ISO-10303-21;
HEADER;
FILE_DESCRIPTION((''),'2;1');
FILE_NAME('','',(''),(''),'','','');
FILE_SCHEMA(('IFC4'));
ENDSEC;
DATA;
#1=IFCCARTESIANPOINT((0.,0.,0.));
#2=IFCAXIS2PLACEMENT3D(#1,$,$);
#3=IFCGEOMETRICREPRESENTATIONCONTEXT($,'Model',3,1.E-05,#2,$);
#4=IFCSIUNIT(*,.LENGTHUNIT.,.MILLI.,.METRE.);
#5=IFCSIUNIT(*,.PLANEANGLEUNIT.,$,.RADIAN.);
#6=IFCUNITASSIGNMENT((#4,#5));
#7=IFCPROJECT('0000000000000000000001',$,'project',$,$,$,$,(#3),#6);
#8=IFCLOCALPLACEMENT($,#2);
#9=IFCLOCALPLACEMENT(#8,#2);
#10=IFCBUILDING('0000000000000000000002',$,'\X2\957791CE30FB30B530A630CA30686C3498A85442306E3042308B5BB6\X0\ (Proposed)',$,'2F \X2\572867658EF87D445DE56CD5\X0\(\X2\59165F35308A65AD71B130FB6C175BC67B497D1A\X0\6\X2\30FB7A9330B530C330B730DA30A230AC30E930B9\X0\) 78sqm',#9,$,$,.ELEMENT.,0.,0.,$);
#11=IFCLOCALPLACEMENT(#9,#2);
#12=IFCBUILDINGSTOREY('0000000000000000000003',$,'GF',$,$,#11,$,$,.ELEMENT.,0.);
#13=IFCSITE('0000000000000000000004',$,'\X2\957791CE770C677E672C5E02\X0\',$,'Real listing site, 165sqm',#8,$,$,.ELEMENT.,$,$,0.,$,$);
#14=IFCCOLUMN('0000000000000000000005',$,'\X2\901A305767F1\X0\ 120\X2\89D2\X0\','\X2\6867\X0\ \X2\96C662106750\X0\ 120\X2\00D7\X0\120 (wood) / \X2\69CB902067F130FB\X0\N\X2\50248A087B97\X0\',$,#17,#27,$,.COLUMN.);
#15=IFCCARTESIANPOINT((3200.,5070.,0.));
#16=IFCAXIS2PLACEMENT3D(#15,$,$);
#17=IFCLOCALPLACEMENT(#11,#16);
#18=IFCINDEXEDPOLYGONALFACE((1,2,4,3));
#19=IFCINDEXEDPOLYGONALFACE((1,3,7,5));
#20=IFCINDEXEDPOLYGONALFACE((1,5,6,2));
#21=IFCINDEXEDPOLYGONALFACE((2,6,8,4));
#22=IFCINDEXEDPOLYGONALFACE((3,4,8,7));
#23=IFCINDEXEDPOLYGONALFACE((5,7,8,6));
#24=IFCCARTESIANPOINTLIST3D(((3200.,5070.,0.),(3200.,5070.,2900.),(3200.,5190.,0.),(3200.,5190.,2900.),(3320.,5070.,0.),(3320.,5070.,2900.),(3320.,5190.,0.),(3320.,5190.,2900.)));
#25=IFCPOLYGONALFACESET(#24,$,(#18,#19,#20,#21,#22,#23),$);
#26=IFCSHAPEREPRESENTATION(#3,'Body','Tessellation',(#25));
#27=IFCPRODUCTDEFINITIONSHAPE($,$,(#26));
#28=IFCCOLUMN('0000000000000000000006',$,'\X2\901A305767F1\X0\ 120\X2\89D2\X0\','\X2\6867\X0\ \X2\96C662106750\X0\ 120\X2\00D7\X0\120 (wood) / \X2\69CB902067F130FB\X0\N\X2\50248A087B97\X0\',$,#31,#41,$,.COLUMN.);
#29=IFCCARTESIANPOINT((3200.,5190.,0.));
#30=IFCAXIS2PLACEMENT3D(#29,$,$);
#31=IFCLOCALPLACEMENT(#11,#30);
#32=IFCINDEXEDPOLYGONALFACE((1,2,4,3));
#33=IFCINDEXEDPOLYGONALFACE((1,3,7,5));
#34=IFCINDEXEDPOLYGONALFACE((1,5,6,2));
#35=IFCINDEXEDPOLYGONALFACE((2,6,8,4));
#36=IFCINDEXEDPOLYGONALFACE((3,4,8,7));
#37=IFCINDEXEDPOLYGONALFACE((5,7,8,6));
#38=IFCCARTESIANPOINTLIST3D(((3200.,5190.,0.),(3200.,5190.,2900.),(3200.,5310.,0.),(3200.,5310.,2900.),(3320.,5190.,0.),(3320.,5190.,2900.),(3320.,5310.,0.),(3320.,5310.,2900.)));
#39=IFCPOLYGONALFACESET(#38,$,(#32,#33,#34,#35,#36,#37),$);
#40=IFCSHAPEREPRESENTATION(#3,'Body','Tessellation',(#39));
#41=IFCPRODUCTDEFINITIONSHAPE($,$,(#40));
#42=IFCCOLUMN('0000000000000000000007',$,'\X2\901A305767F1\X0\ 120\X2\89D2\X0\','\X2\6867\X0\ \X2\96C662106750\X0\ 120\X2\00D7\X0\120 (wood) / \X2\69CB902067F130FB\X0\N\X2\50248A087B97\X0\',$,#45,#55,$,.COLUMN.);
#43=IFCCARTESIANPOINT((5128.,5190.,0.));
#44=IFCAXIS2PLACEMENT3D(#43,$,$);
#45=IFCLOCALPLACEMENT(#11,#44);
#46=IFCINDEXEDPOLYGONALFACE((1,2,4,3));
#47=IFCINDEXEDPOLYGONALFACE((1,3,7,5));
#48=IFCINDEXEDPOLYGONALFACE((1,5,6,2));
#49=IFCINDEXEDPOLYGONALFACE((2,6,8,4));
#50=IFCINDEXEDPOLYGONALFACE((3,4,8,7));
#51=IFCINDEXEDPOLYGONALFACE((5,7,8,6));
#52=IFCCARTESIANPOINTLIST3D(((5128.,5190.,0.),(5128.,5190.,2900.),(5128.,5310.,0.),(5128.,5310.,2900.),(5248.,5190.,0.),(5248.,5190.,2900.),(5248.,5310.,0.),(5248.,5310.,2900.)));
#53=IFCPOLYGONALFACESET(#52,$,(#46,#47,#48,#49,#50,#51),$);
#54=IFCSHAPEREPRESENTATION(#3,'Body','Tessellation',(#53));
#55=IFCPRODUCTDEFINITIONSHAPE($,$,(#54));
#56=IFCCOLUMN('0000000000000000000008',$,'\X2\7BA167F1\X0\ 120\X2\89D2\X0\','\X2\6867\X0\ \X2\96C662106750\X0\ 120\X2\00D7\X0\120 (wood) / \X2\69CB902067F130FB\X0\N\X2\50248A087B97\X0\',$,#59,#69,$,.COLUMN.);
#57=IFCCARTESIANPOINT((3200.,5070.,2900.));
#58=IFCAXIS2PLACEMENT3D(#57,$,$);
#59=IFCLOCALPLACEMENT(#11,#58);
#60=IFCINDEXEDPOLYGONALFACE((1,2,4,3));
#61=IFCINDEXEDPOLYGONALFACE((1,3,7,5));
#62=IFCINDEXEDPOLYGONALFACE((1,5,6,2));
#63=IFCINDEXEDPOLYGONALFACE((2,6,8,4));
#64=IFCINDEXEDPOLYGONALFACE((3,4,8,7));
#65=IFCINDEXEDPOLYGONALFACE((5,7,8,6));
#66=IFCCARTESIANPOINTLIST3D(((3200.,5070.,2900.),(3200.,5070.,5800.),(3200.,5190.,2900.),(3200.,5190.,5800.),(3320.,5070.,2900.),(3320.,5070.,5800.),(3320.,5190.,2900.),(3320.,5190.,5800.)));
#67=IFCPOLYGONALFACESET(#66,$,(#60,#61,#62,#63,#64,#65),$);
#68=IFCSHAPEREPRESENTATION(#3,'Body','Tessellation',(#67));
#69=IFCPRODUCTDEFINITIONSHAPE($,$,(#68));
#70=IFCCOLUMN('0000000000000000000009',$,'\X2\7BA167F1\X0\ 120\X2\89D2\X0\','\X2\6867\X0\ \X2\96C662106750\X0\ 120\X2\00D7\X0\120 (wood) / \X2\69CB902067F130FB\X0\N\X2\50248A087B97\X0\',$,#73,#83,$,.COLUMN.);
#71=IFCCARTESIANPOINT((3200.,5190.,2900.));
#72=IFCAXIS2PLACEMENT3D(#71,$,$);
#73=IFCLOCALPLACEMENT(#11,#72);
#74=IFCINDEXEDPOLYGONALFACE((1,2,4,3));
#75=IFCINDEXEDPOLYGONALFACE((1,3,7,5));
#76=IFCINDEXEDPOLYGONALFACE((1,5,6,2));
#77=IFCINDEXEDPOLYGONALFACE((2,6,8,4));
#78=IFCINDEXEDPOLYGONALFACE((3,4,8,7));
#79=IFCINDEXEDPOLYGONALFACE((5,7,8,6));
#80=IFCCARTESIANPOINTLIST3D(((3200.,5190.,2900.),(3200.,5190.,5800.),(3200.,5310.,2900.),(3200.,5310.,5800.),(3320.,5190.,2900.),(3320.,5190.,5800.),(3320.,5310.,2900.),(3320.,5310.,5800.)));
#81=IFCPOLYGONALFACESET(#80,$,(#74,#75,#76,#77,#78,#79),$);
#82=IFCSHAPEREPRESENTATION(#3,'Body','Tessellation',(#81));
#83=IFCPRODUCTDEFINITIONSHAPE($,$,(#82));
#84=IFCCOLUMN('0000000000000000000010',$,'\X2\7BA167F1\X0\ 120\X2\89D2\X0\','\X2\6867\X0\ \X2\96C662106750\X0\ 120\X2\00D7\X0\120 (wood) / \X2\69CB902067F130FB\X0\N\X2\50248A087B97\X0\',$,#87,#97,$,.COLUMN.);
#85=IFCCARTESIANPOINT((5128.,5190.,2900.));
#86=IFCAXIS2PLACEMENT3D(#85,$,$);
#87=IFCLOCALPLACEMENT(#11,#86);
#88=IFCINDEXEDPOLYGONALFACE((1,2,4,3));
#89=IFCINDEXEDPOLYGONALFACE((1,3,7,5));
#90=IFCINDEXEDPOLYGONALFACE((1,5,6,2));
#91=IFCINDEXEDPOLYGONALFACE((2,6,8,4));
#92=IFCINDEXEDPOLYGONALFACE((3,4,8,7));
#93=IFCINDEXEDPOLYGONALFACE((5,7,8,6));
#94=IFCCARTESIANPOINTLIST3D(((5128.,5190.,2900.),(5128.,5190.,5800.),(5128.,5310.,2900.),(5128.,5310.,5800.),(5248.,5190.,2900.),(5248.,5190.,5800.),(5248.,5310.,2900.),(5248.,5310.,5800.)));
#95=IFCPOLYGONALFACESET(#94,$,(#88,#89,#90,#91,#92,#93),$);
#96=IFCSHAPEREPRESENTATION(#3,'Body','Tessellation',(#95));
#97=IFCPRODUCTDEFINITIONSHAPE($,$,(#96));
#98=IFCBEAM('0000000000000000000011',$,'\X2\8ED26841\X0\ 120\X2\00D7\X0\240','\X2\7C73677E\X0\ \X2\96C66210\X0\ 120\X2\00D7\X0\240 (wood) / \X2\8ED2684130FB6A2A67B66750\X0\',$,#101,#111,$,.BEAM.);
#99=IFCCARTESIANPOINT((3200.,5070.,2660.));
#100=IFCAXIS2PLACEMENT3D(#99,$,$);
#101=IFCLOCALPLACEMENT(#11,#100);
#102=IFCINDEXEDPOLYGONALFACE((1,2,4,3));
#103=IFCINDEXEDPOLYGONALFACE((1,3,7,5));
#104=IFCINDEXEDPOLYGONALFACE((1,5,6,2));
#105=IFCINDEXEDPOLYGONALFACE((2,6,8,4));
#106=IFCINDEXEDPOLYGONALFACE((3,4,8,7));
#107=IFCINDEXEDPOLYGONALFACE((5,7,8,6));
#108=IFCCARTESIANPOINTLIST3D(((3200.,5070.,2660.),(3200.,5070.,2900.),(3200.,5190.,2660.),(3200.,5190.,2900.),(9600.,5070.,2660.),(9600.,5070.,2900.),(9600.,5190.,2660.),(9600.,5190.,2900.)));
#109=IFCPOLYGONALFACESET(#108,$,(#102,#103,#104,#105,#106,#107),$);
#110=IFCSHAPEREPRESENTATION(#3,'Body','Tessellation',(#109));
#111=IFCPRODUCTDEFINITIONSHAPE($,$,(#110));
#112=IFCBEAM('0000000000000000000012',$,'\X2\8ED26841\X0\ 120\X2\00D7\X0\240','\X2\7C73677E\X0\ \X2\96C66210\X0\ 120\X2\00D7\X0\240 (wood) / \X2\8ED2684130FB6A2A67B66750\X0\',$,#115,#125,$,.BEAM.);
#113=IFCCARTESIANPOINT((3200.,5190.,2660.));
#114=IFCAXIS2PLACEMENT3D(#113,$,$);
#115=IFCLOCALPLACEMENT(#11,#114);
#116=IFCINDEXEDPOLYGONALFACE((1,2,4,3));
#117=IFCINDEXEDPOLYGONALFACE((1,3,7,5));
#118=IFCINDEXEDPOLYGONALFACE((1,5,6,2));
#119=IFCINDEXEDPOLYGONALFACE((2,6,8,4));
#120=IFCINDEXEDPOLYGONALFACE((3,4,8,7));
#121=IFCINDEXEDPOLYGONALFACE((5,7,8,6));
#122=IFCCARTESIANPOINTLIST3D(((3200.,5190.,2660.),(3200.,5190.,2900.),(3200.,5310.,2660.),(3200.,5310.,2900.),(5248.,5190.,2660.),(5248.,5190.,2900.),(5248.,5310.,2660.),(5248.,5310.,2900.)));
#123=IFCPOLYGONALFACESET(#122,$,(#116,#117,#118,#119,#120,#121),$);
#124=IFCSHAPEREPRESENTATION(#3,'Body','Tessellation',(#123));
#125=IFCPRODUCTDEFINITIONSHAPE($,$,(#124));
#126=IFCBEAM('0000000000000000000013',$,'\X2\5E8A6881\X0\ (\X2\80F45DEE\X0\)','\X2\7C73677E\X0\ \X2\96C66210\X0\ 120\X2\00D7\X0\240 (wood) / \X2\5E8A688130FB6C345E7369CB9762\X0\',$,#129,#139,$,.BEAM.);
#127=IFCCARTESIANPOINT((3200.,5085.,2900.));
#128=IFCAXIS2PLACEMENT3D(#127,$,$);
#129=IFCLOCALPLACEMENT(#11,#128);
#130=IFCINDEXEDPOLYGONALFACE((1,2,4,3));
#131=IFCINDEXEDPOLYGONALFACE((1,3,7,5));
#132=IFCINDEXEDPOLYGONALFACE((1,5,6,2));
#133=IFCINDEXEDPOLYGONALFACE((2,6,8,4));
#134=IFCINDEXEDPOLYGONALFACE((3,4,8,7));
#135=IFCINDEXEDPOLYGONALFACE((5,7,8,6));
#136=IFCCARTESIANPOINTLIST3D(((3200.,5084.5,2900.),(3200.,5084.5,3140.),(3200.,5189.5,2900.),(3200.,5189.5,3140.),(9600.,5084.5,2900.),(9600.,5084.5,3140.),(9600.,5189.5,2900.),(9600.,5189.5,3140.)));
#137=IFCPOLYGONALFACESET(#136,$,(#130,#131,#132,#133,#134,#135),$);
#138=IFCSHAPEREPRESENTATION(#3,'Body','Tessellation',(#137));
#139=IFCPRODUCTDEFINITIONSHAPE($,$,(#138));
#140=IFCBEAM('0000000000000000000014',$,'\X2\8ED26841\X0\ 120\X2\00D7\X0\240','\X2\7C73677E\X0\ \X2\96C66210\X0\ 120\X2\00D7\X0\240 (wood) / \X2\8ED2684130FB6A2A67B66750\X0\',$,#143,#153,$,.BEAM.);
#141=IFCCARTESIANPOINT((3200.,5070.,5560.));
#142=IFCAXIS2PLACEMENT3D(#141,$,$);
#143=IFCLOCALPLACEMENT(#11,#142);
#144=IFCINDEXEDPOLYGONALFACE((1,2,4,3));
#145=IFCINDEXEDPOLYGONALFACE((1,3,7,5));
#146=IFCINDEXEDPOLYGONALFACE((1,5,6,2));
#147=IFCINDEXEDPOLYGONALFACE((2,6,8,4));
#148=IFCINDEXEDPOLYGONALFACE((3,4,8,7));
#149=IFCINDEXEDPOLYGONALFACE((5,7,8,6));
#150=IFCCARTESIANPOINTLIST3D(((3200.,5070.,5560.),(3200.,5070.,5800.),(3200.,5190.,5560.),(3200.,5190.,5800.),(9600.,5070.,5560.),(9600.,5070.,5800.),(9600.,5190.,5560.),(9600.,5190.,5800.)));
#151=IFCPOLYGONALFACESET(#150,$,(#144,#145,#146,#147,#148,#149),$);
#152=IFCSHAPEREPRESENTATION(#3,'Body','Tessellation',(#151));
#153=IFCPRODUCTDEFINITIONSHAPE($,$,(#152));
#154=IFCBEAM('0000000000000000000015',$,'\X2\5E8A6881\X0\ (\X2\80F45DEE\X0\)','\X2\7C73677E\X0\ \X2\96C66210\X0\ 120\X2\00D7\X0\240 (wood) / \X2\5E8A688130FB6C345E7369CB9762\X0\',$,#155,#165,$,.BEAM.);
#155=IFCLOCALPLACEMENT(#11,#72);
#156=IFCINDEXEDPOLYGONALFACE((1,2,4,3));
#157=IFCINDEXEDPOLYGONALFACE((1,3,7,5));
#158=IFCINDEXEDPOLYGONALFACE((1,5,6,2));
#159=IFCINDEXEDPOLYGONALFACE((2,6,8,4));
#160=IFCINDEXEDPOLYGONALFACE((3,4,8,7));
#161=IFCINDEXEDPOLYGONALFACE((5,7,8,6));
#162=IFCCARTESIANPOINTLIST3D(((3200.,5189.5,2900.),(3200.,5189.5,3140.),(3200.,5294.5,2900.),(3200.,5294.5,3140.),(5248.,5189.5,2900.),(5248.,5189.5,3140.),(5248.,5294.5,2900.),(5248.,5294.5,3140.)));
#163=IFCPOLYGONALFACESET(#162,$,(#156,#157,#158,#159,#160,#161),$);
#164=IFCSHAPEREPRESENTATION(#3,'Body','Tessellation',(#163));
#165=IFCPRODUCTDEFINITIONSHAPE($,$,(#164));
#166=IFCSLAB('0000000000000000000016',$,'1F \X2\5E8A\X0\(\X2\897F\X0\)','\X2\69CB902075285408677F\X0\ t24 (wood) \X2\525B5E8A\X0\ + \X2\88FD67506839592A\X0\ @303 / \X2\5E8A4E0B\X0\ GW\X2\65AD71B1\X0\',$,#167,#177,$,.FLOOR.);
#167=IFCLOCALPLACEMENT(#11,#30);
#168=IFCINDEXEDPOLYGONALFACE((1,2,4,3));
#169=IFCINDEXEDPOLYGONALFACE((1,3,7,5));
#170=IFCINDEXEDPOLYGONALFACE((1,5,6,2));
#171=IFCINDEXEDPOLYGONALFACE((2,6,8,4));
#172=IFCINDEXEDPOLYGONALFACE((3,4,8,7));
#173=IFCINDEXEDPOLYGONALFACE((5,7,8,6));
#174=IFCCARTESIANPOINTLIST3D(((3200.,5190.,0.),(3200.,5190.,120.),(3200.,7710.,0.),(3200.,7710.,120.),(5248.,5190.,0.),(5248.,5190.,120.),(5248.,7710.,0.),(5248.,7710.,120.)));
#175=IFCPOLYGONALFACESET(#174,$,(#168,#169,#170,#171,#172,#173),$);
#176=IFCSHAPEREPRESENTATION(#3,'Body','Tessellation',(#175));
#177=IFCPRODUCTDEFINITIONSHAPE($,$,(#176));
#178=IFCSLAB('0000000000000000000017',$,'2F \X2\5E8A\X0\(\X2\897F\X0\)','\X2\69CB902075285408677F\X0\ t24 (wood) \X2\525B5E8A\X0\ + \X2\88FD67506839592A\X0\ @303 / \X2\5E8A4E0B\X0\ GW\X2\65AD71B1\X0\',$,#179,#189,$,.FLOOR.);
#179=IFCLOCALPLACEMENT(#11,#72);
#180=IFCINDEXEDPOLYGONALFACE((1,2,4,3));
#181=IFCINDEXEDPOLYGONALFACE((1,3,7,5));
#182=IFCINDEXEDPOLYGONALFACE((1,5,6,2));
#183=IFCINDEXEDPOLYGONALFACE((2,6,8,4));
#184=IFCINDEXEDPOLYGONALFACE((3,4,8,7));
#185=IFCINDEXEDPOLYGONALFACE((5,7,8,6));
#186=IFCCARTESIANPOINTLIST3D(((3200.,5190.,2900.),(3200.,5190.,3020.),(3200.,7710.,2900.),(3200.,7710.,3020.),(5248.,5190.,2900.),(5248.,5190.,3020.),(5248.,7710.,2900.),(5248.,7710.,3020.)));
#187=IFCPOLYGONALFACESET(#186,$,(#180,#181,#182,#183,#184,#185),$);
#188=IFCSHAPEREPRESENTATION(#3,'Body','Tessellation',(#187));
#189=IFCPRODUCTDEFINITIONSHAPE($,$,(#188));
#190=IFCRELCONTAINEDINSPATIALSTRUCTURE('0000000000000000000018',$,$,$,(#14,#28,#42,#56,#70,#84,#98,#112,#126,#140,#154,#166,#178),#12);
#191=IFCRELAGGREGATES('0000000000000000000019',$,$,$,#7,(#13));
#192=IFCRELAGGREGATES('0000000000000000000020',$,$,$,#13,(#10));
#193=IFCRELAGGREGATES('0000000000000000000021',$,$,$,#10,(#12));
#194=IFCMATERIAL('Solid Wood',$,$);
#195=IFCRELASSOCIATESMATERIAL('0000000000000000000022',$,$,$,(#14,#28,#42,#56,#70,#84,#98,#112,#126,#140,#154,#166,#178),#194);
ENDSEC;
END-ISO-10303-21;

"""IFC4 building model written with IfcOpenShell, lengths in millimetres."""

from ifc_helpers import new_model, si_unit, frame, frame_2d, origin, place, context, project, spatial, rectangle, extrude, material, element, save


model = new_model("IFC4")

# Units and contexts
model_context = context("Model", 3, precision=1e-05, world=origin())
ifc_project = project(units=[si_unit("LENGTHUNIT", "METRE", prefix="MILLI"), si_unit("PLANEANGLEUNIT", "RADIAN")], contexts=[model_context])

# Site, building, storey
site_placement = place(None, origin())
site = spatial("IfcSite", under=ifc_project, at=site_placement, Name="長野県松本市", ObjectType="Real listing site, 165sqm", CompositionType="ELEMENT", RefElevation=0.0)
building_placement = place(site_placement, origin())
building = spatial("IfcBuilding", under=site, at=building_placement, Name="長野・サウナと水風呂のある家 (Proposed)", ObjectType="2F 在来軸組工法(外張り断熱・気密等級6・窓サッシペアガラス) 78sqm", CompositionType="ELEMENT", ElevationOfRefHeight=0.0, ElevationOfTerrain=0.0)
storey_placement = place(building_placement, origin())
storey = spatial("IfcBuildingStorey", under=building, at=storey_placement, Name="GF", CompositionType="ELEMENT", Elevation=0.0)

# Columns
ifc_material_1 = material(Name="Solid Wood")
column_1_placement = place(storey_placement, frame((3200.0, 5070.0, 0.0)))
element("IfcColumn", 1, at=column_1_placement, inside=storey, material=ifc_material_1, Name="通し柱 120角", Description="桧 集成材 120×120 (wood) / 構造柱・N値計算", PredefinedType="COLUMN", context=model_context, shape_type="SweptSolid", body=[
    extrude(rectangle(XDim=120.0, YDim=120.0, at=frame_2d((60.0, 60.0))), frame((3200.0, 5070.0, 0.0)), (0.0, 0.0, 1.0), 2900.0),
])
column_2_placement = place(storey_placement, frame((3200.0, 5190.0, 0.0)))
element("IfcColumn", 2, at=column_2_placement, inside=storey, material=ifc_material_1, Name="通し柱 120角", Description="桧 集成材 120×120 (wood) / 構造柱・N値計算", PredefinedType="COLUMN", context=model_context, shape_type="SweptSolid", body=[
    extrude(rectangle(XDim=120.0, YDim=120.0, at=frame_2d((60.0, 60.0))), frame((3200.0, 5190.0, 0.0)), (0.0, 0.0, 1.0), 2900.0),
])
column_3_placement = place(storey_placement, frame((5128.0, 5190.0, 0.0)))
element("IfcColumn", 3, at=column_3_placement, inside=storey, material=ifc_material_1, Name="通し柱 120角", Description="桧 集成材 120×120 (wood) / 構造柱・N値計算", PredefinedType="COLUMN", context=model_context, shape_type="SweptSolid", body=[
    extrude(rectangle(XDim=120.0, YDim=120.0, at=frame_2d((60.0, 60.0))), frame((5128.0, 5190.0, 0.0)), (0.0, 0.0, 1.0), 2900.0),
])
column_4_placement = place(storey_placement, frame((3200.0, 5070.0, 2900.0)))
element("IfcColumn", 4, at=column_4_placement, inside=storey, material=ifc_material_1, Name="管柱 120角", Description="桧 集成材 120×120 (wood) / 構造柱・N値計算", PredefinedType="COLUMN", context=model_context, shape_type="SweptSolid", body=[
    extrude(rectangle(XDim=120.0, YDim=120.0, at=frame_2d((60.0, 60.0))), frame((3200.0, 5070.0, 2900.0)), (0.0, 0.0, 1.0), 2900.0),
])
column_5_placement = place(storey_placement, frame((3200.0, 5190.0, 2900.0)))
element("IfcColumn", 5, at=column_5_placement, inside=storey, material=ifc_material_1, Name="管柱 120角", Description="桧 集成材 120×120 (wood) / 構造柱・N値計算", PredefinedType="COLUMN", context=model_context, shape_type="SweptSolid", body=[
    extrude(rectangle(XDim=120.0, YDim=120.0, at=frame_2d((60.0, 60.0))), frame((3200.0, 5190.0, 2900.0)), (0.0, 0.0, 1.0), 2900.0),
])
column_6_placement = place(storey_placement, frame((5128.0, 5190.0, 2900.0)))
element("IfcColumn", 6, at=column_6_placement, inside=storey, material=ifc_material_1, Name="管柱 120角", Description="桧 集成材 120×120 (wood) / 構造柱・N値計算", PredefinedType="COLUMN", context=model_context, shape_type="SweptSolid", body=[
    extrude(rectangle(XDim=120.0, YDim=120.0, at=frame_2d((60.0, 60.0))), frame((5128.0, 5190.0, 2900.0)), (0.0, 0.0, 1.0), 2900.0),
])

# Beams
beam_1_placement = place(storey_placement, frame((3200.0, 5070.0, 2660.0)))
element("IfcBeam", 7, at=beam_1_placement, inside=storey, material=ifc_material_1, Name="軒桁 120×240", Description="米松 集成 120×240 (wood) / 軒桁・横架材", PredefinedType="BEAM", context=model_context, shape_type="SweptSolid", body=[
    extrude(rectangle(XDim=6400.0, YDim=120.0, at=frame_2d((3200.0, 60.0))), frame((3200.0, 5070.0, 2660.0)), (0.0, 0.0, 1.0), 240.0),
])
beam_2_placement = place(storey_placement, frame((3200.0, 5190.0, 2660.0)))
element("IfcBeam", 8, at=beam_2_placement, inside=storey, material=ifc_material_1, Name="軒桁 120×240", Description="米松 集成 120×240 (wood) / 軒桁・横架材", PredefinedType="BEAM", context=model_context, shape_type="SweptSolid", body=[
    extrude(rectangle(XDim=2048.0, YDim=120.0, at=frame_2d((1024.0, 60.0))), frame((3200.0, 5190.0, 2660.0)), (0.0, 0.0, 1.0), 240.0),
])
beam_3_placement = place(storey_placement, frame((3200.0, 5085.0, 2900.0)))
element("IfcBeam", 9, at=beam_3_placement, inside=storey, material=ifc_material_1, Name="床梁 (胴差)", Description="米松 集成 120×240 (wood) / 床梁・水平構面", PredefinedType="BEAM", context=model_context, shape_type="SweptSolid", body=[
    extrude(rectangle(XDim=6400.0, YDim=105.0, at=frame_2d((3200.0, 52.0))), frame((3200.0, 5085.0, 2900.0)), (0.0, 0.0, 1.0), 240.0),
])
beam_4_placement = place(storey_placement, frame((3200.0, 5070.0, 5560.0)))
element("IfcBeam", 10, at=beam_4_placement, inside=storey, material=ifc_material_1, Name="軒桁 120×240", Description="米松 集成 120×240 (wood) / 軒桁・横架材", PredefinedType="BEAM", context=model_context, shape_type="SweptSolid", body=[
    extrude(rectangle(XDim=6400.0, YDim=120.0, at=frame_2d((3200.0, 60.0))), frame((3200.0, 5070.0, 5560.0)), (0.0, 0.0, 1.0), 240.0),
])
beam_5_placement = place(storey_placement, frame((3200.0, 5190.0, 2900.0)))
element("IfcBeam", 11, at=beam_5_placement, inside=storey, material=ifc_material_1, Name="床梁 (胴差)", Description="米松 集成 120×240 (wood) / 床梁・水平構面", PredefinedType="BEAM", context=model_context, shape_type="SweptSolid", body=[
    extrude(rectangle(XDim=2048.0, YDim=105.0, at=frame_2d((1024.0, 52.0))), frame((3200.0, 5190.0, 2900.0)), (0.0, 0.0, 1.0), 240.0),
])

# Slabs
slab_1_placement = place(storey_placement, frame((3200.0, 5190.0, 0.0)))
element("IfcSlab", 12, at=slab_1_placement, inside=storey, material=ifc_material_1, Name="1F 床(西)", Description="構造用合板 t24 (wood) 剛床 + 製材根太 @303 / 床下 GW断熱", PredefinedType="FLOOR", context=model_context, shape_type="SweptSolid", body=[
    extrude(rectangle(XDim=2048.0, YDim=2520.0, at=frame_2d((1024.0, 1260.0))), frame((3200.0, 5190.0, 0.0)), (0.0, 0.0, 1.0), 120.0),
])
slab_2_placement = place(storey_placement, frame((3200.0, 5190.0, 2900.0)))
element("IfcSlab", 13, at=slab_2_placement, inside=storey, material=ifc_material_1, Name="2F 床(西)", Description="構造用合板 t24 (wood) 剛床 + 製材根太 @303 / 床下 GW断熱", PredefinedType="FLOOR", context=model_context, shape_type="SweptSolid", body=[
    extrude(rectangle(XDim=2048.0, YDim=2520.0, at=frame_2d((1024.0, 1260.0))), frame((3200.0, 5190.0, 2900.0)), (0.0, 0.0, 1.0), 120.0),
])

save(model, "model.ifc")
